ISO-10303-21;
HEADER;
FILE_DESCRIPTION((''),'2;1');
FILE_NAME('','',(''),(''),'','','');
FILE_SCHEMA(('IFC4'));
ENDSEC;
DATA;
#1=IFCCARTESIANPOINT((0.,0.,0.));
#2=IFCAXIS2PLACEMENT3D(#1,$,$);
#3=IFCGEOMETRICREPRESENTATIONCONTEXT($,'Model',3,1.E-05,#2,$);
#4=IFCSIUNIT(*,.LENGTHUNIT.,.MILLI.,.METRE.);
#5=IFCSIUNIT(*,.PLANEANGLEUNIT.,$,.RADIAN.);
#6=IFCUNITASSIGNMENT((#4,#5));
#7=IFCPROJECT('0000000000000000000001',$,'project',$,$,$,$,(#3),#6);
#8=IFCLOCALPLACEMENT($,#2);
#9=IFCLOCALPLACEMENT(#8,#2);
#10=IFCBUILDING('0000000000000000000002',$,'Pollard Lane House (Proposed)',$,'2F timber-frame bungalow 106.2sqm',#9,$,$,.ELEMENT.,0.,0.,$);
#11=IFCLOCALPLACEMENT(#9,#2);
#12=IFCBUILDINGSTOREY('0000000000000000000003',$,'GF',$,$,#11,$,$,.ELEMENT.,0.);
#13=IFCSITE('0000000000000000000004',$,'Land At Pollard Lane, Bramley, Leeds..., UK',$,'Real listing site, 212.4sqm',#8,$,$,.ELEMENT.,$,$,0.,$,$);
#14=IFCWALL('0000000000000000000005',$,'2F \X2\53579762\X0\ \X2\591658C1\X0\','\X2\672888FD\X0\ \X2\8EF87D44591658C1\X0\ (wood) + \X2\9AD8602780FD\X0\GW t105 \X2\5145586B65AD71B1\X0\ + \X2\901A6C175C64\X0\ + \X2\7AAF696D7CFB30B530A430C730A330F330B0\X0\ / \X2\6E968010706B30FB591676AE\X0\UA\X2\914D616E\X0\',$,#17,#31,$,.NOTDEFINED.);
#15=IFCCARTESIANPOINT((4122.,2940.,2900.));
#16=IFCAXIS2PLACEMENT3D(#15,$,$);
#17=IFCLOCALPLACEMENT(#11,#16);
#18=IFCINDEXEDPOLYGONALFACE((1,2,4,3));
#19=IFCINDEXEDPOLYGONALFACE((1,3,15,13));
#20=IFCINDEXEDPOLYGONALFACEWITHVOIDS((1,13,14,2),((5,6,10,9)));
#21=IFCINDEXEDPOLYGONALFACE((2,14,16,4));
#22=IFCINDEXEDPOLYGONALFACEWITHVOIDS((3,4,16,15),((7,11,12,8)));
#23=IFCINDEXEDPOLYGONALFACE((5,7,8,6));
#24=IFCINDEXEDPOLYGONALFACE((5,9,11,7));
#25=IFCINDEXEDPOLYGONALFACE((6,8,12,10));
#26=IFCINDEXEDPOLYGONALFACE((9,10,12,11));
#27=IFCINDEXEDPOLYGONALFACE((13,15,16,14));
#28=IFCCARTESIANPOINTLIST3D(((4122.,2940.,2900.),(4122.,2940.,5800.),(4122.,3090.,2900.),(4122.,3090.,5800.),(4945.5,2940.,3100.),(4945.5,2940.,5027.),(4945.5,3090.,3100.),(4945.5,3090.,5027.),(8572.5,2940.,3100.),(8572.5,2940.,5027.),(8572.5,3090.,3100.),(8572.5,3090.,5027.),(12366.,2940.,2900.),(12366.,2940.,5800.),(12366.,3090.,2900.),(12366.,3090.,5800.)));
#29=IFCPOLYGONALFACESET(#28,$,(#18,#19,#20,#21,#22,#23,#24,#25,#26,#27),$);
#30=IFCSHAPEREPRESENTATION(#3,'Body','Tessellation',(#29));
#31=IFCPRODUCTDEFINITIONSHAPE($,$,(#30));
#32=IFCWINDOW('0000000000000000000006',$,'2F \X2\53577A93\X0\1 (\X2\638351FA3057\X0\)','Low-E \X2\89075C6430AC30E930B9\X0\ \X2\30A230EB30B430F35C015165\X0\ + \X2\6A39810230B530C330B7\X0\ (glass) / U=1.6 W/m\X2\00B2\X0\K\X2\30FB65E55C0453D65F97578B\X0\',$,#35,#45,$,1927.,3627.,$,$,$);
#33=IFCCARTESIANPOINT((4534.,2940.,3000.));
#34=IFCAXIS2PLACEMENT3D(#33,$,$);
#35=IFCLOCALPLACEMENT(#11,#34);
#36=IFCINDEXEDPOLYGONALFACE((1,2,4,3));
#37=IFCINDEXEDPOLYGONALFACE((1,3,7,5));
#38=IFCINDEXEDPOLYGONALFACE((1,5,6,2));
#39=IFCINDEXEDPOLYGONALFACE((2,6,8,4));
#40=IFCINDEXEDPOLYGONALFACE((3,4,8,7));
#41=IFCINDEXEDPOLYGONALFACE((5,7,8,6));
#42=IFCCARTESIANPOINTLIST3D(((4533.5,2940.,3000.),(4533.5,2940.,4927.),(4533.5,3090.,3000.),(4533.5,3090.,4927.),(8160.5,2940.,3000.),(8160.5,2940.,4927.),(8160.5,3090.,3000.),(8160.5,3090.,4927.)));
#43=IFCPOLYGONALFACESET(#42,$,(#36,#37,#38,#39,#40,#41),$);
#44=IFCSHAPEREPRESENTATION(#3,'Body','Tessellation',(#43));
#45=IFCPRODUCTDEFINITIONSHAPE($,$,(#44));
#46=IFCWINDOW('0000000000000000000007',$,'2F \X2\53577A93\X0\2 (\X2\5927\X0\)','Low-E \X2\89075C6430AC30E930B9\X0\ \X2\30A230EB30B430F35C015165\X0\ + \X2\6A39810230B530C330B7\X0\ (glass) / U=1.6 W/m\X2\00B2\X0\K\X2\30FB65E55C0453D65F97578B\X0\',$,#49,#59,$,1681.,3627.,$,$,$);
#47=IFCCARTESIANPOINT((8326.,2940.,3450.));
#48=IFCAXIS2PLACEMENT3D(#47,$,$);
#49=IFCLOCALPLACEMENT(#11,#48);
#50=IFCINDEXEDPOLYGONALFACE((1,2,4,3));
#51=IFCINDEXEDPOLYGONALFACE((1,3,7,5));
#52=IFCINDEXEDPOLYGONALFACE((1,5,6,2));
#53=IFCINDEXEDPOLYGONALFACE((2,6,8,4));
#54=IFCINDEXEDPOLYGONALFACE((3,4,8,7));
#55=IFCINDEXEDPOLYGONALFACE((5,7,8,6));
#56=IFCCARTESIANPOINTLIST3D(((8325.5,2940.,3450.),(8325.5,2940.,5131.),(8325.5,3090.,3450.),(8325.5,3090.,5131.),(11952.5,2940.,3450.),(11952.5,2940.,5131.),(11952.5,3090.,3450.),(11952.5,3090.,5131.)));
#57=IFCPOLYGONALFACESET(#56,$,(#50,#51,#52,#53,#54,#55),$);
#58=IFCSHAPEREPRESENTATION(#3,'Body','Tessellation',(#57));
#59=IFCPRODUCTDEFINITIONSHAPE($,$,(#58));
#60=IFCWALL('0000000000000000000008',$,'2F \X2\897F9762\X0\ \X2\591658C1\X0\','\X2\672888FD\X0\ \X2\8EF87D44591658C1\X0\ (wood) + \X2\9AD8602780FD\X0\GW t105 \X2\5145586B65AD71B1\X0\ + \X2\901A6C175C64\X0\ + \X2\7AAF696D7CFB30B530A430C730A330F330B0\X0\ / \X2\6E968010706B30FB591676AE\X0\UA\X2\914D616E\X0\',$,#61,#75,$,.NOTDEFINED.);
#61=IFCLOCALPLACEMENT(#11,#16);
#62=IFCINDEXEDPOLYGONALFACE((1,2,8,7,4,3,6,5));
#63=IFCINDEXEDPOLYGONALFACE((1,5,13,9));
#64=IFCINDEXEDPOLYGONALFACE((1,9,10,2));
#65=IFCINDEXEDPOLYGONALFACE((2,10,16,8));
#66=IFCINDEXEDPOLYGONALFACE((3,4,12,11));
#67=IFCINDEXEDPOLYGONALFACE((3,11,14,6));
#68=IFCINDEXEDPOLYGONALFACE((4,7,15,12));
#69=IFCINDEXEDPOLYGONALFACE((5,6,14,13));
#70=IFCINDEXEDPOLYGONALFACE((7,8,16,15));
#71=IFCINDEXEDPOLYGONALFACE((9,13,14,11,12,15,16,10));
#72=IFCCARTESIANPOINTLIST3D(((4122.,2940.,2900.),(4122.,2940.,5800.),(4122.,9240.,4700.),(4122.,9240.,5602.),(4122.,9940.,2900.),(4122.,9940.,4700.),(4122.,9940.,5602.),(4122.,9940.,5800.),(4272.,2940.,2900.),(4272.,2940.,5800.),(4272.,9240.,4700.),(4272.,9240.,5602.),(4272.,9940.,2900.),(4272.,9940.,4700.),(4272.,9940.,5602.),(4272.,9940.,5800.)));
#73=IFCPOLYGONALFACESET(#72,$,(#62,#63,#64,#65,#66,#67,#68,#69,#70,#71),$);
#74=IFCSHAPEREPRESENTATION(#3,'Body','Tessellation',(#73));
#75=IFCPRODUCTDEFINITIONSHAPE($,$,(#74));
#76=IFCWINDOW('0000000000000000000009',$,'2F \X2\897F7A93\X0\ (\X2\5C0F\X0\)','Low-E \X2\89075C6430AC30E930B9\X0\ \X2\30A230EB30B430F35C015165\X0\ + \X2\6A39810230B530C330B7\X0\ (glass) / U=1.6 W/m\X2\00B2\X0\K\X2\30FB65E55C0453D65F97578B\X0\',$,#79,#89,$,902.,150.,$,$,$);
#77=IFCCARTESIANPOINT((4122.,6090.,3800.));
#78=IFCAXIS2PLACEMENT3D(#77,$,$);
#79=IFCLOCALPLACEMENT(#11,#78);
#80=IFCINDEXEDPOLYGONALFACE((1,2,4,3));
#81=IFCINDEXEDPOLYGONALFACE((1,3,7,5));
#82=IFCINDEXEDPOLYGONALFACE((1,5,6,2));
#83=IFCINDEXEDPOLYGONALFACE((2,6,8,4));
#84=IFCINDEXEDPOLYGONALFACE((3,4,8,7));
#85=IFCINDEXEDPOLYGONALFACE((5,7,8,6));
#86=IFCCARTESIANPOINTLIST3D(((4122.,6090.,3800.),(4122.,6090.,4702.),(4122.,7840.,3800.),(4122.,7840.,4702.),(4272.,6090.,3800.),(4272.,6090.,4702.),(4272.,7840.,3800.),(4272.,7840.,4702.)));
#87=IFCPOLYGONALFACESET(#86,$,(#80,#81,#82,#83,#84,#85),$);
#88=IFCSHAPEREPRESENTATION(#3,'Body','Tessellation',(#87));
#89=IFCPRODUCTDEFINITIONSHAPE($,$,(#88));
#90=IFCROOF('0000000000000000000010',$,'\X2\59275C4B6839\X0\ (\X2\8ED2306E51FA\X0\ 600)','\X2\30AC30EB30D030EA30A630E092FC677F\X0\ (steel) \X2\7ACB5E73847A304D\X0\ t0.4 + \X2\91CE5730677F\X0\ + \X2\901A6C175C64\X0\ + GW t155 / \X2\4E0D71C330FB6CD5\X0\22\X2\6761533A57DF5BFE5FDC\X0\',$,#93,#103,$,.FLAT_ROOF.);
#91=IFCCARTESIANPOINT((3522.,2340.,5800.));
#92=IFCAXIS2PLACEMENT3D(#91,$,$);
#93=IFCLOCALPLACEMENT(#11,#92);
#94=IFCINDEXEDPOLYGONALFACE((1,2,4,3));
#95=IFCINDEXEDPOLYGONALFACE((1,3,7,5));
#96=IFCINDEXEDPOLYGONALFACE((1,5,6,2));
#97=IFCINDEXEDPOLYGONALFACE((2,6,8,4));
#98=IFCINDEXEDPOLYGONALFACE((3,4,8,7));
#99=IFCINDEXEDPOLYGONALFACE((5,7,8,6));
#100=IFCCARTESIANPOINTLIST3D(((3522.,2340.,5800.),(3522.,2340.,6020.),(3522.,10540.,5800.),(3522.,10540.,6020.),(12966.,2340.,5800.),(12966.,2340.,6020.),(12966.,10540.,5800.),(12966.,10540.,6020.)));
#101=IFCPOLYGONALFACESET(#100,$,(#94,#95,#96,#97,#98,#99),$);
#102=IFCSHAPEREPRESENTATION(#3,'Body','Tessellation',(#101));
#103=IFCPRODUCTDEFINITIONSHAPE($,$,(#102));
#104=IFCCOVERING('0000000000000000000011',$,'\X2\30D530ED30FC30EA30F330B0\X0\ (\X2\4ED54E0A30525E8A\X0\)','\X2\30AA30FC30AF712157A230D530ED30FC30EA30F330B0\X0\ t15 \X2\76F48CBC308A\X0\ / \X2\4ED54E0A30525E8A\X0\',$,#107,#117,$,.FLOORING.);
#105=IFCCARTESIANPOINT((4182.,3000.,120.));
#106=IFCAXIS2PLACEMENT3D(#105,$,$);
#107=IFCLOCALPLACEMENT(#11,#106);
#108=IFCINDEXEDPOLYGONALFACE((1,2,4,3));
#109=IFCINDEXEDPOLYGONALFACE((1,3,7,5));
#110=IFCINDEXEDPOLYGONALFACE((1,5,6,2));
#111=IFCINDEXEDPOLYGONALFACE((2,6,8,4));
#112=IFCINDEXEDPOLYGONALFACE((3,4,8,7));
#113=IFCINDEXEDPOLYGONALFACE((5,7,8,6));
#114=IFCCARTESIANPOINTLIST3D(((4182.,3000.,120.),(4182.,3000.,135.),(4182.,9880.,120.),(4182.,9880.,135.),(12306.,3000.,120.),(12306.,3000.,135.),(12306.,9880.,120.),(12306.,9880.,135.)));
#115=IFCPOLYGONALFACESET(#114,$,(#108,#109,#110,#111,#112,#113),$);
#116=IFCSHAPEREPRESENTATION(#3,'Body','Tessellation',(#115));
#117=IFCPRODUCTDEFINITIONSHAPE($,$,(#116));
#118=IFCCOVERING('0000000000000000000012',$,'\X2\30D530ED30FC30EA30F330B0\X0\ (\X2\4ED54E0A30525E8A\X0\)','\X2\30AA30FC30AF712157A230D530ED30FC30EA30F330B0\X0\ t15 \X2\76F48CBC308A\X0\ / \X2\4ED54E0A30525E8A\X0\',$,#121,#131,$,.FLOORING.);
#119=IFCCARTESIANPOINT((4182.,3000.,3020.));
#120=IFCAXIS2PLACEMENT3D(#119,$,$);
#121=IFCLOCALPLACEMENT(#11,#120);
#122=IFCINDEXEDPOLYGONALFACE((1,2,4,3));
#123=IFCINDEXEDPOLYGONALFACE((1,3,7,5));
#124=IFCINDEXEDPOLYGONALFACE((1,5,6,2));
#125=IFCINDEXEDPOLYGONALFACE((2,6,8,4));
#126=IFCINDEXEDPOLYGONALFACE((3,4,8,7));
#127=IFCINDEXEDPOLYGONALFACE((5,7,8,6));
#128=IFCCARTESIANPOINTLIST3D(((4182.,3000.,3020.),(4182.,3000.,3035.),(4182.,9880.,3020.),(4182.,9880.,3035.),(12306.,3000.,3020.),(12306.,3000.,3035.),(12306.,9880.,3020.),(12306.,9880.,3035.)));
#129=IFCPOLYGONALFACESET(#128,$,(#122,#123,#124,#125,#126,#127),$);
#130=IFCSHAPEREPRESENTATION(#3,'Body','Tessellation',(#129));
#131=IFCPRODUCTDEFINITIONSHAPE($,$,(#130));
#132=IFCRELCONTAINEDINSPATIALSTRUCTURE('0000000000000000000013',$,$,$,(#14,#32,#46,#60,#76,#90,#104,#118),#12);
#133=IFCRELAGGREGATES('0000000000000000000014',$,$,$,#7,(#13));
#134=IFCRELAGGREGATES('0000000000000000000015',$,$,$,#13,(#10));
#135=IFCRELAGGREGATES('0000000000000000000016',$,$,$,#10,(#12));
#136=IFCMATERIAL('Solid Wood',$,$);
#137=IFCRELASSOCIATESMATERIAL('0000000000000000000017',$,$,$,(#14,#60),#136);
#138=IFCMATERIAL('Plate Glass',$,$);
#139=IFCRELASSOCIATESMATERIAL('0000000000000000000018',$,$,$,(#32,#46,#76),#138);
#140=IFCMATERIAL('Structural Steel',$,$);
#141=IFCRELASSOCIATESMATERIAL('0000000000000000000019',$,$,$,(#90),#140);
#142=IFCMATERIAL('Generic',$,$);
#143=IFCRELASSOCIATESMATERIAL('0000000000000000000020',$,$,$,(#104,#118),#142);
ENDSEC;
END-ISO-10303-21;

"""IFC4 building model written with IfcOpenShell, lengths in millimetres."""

from ifc_helpers import new_model, si_unit, frame, frame_2d, origin, place, context, project, spatial, rectangle, extrude, material, element, fill, save


model = new_model("IFC4")

# Units and contexts
model_context = context("Model", 3, precision=1e-05, world=origin())
ifc_project = project(units=[si_unit("LENGTHUNIT", "METRE", prefix="MILLI"), si_unit("PLANEANGLEUNIT", "RADIAN")], contexts=[model_context])

# Site, building, storey
site_placement = place(None, origin())
site = spatial("IfcSite", under=ifc_project, at=site_placement, Name="Land At Pollard Lane, Bramley, Leeds..., UK", ObjectType="Real listing site, 212.4sqm", CompositionType="ELEMENT", RefElevation=0.0)
building_placement = place(site_placement, origin())
building = spatial("IfcBuilding", under=site, at=building_placement, Name="Pollard Lane House (Proposed)", ObjectType="2F timber-frame bungalow 106.2sqm", CompositionType="ELEMENT", ElevationOfRefHeight=0.0, ElevationOfTerrain=0.0)
storey_placement = place(building_placement, origin())
storey = spatial("IfcBuildingStorey", under=building, at=storey_placement, Name="GF", CompositionType="ELEMENT", Elevation=0.0)

# Shared definitions
ifc_material_1 = material(Name="Solid Wood")

# Shared definitions
ifc_material_2 = material(Name="Plate Glass")

# Wall, openings, windows
wall_1_placement = place(storey_placement, frame((4122.0, 2940.0, 2900.0)))
wall_1 = element("IfcWall", 1, at=wall_1_placement, inside=storey, material=ifc_material_1, Name="2F 南面 外壁", Description="木製 軸組外壁 (wood) + 高性能GW t105 充填断熱 + 通気層 + 窯業系サイディング / 準耐火・外皮UA配慮", PredefinedType="NOTDEFINED", context=model_context, shape_type="SweptSolid", body=[
    extrude(rectangle(XDim=8244.0, YDim=150.0, at=frame_2d((4122.0, 75.0))), frame((4122.0, 2940.0, 2900.0)), (0.0, 0.0, 1.0), 2900.0),
])
opening_1_placement = place(storey_placement, frame((4534.0, 2940.0, 3000.0)))
opening_1 = element("IfcOpeningElement", 2, at=opening_1_placement, cuts=wall_1, PredefinedType="NOTDEFINED", context=model_context, shape_type="SweptSolid", body=[
    extrude(rectangle(XDim=3627.0, YDim=150.0, at=frame_2d((1813.0, 75.0))), frame((4534.0, 2940.0, 3000.0)), (0.0, 0.0, 1.0), 1927.0),
])
opening_2_placement = place(storey_placement, frame((8326.0, 2940.0, 3450.0)))
opening_2 = element("IfcOpeningElement", 3, at=opening_2_placement, cuts=wall_1, PredefinedType="NOTDEFINED", context=model_context, shape_type="SweptSolid", body=[
    extrude(rectangle(XDim=3627.0, YDim=150.0, at=frame_2d((1813.0, 75.0))), frame((8326.0, 2940.0, 3450.0)), (0.0, 0.0, 1.0), 1681.0),
])
window_1_placement = place(storey_placement, frame((4534.0, 2940.0, 3000.0)))
window_1 = element("IfcWindow", 4, at=window_1_placement, inside=storey, material=ifc_material_2, Name="2F 南窓1 (掃出し)", Description="Low-E 複層ガラス アルゴン封入 + 樹脂サッシ (glass) / U=1.6 W/m²K・日射取得型", OverallHeight=1927.0, OverallWidth=3627.0, context=model_context, shape_type="SweptSolid", body=[
    extrude(rectangle(XDim=3627.0, YDim=150.0, at=frame_2d((1813.0, 75.0))), frame((4534.0, 2940.0, 3000.0)), (0.0, 0.0, 1.0), 1927.0),
])
fill(opening_1, window_1)
window_2_placement = place(storey_placement, frame((8326.0, 2940.0, 3450.0)))
window_2 = element("IfcWindow", 5, at=window_2_placement, inside=storey, material=ifc_material_2, Name="2F 南窓2 (大)", Description="Low-E 複層ガラス アルゴン封入 + 樹脂サッシ (glass) / U=1.6 W/m²K・日射取得型", OverallHeight=1681.0, OverallWidth=3627.0, context=model_context, shape_type="SweptSolid", body=[
    extrude(rectangle(XDim=3627.0, YDim=150.0, at=frame_2d((1813.0, 75.0))), frame((8326.0, 2940.0, 3450.0)), (0.0, 0.0, 1.0), 1681.0),
])
fill(opening_2, window_2)

# Wall, opening, window
wall_2_placement = place(storey_placement, frame((4122.0, 2940.0, 2900.0)))
wall_2 = element("IfcWall", 6, at=wall_2_placement, inside=storey, material=ifc_material_1, Name="2F 西面 外壁", Description="木製 軸組外壁 (wood) + 高性能GW t105 充填断熱 + 通気層 + 窯業系サイディング / 準耐火・外皮UA配慮", PredefinedType="NOTDEFINED", context=model_context, shape_type="SweptSolid", body=[
    extrude(rectangle(XDim=150.0, YDim=7000.0, at=frame_2d((75.0, 3500.0))), frame((4122.0, 2940.0, 2900.0)), (0.0, 0.0, 1.0), 2900.0),
])
opening_3_placement = place(storey_placement, frame((4122.0, 6090.0, 3800.0)))
opening_3 = element("IfcOpeningElement", 7, at=opening_3_placement, cuts=wall_2, PredefinedType="NOTDEFINED", context=model_context, shape_type="SweptSolid", body=[
    extrude(rectangle(XDim=150.0, YDim=1750.0, at=frame_2d((75.0, 875.0))), frame((4122.0, 6090.0, 3800.0)), (0.0, 0.0, 1.0), 902.0),
])
window_3_placement = place(storey_placement, frame((4122.0, 6090.0, 3800.0)))
window_3 = element("IfcWindow", 8, at=window_3_placement, inside=storey, material=ifc_material_2, Name="2F 西窓 (小)", Description="Low-E 複層ガラス アルゴン封入 + 樹脂サッシ (glass) / U=1.6 W/m²K・日射取得型", OverallHeight=902.0, OverallWidth=150.0, context=model_context, shape_type="SweptSolid", body=[
    extrude(rectangle(XDim=150.0, YDim=1750.0, at=frame_2d((75.0, 875.0))), frame((4122.0, 6090.0, 3800.0)), (0.0, 0.0, 1.0), 902.0),
])
fill(opening_3, window_3)

# Roof
ifc_material_3 = material(Name="Structural Steel")
roof_placement = place(storey_placement, frame((3522.0, 2340.0, 5800.0)))
element("IfcRoof", 9, at=roof_placement, inside=storey, material=ifc_material_3, Name="大屋根 (軒の出 600)", Description="ガルバリウム鋼板 (steel) 立平葺き t0.4 + 野地板 + 通気層 + GW t155 / 不燃・法22条区域対応", PredefinedType="FLAT_ROOF", context=model_context, shape_type="SweptSolid", body=[
    extrude(rectangle(XDim=9444.0, YDim=8200.0, at=frame_2d((4722.0, 4100.0))), frame((3522.0, 2340.0, 5800.0)), (0.0, 0.0, 1.0), 220.0),
])

# Coverings
ifc_material_4 = material(Name="Generic")
covering_1_placement = place(storey_placement, frame((4182.0, 3000.0, 120.0)))
element("IfcCovering", 10, at=covering_1_placement, inside=storey, material=ifc_material_4, Name="フローリング (仕上げ床)", Description="オーク無垢フローリング t15 直貼り / 仕上げ床", PredefinedType="FLOORING", context=model_context, shape_type="SweptSolid", body=[
    extrude(rectangle(XDim=8124.0, YDim=6880.0, at=frame_2d((4062.0, 3440.0))), frame((4182.0, 3000.0, 120.0)), (0.0, 0.0, 1.0), 15.0),
])
covering_2_placement = place(storey_placement, frame((4182.0, 3000.0, 3020.0)))
element("IfcCovering", 11, at=covering_2_placement, inside=storey, material=ifc_material_4, Name="フローリング (仕上げ床)", Description="オーク無垢フローリング t15 直貼り / 仕上げ床", PredefinedType="FLOORING", context=model_context, shape_type="SweptSolid", body=[
    extrude(rectangle(XDim=8124.0, YDim=6880.0, at=frame_2d((4062.0, 3440.0))), frame((4182.0, 3000.0, 3020.0)), (0.0, 0.0, 1.0), 15.0),
])

save(model, "model.ifc")
